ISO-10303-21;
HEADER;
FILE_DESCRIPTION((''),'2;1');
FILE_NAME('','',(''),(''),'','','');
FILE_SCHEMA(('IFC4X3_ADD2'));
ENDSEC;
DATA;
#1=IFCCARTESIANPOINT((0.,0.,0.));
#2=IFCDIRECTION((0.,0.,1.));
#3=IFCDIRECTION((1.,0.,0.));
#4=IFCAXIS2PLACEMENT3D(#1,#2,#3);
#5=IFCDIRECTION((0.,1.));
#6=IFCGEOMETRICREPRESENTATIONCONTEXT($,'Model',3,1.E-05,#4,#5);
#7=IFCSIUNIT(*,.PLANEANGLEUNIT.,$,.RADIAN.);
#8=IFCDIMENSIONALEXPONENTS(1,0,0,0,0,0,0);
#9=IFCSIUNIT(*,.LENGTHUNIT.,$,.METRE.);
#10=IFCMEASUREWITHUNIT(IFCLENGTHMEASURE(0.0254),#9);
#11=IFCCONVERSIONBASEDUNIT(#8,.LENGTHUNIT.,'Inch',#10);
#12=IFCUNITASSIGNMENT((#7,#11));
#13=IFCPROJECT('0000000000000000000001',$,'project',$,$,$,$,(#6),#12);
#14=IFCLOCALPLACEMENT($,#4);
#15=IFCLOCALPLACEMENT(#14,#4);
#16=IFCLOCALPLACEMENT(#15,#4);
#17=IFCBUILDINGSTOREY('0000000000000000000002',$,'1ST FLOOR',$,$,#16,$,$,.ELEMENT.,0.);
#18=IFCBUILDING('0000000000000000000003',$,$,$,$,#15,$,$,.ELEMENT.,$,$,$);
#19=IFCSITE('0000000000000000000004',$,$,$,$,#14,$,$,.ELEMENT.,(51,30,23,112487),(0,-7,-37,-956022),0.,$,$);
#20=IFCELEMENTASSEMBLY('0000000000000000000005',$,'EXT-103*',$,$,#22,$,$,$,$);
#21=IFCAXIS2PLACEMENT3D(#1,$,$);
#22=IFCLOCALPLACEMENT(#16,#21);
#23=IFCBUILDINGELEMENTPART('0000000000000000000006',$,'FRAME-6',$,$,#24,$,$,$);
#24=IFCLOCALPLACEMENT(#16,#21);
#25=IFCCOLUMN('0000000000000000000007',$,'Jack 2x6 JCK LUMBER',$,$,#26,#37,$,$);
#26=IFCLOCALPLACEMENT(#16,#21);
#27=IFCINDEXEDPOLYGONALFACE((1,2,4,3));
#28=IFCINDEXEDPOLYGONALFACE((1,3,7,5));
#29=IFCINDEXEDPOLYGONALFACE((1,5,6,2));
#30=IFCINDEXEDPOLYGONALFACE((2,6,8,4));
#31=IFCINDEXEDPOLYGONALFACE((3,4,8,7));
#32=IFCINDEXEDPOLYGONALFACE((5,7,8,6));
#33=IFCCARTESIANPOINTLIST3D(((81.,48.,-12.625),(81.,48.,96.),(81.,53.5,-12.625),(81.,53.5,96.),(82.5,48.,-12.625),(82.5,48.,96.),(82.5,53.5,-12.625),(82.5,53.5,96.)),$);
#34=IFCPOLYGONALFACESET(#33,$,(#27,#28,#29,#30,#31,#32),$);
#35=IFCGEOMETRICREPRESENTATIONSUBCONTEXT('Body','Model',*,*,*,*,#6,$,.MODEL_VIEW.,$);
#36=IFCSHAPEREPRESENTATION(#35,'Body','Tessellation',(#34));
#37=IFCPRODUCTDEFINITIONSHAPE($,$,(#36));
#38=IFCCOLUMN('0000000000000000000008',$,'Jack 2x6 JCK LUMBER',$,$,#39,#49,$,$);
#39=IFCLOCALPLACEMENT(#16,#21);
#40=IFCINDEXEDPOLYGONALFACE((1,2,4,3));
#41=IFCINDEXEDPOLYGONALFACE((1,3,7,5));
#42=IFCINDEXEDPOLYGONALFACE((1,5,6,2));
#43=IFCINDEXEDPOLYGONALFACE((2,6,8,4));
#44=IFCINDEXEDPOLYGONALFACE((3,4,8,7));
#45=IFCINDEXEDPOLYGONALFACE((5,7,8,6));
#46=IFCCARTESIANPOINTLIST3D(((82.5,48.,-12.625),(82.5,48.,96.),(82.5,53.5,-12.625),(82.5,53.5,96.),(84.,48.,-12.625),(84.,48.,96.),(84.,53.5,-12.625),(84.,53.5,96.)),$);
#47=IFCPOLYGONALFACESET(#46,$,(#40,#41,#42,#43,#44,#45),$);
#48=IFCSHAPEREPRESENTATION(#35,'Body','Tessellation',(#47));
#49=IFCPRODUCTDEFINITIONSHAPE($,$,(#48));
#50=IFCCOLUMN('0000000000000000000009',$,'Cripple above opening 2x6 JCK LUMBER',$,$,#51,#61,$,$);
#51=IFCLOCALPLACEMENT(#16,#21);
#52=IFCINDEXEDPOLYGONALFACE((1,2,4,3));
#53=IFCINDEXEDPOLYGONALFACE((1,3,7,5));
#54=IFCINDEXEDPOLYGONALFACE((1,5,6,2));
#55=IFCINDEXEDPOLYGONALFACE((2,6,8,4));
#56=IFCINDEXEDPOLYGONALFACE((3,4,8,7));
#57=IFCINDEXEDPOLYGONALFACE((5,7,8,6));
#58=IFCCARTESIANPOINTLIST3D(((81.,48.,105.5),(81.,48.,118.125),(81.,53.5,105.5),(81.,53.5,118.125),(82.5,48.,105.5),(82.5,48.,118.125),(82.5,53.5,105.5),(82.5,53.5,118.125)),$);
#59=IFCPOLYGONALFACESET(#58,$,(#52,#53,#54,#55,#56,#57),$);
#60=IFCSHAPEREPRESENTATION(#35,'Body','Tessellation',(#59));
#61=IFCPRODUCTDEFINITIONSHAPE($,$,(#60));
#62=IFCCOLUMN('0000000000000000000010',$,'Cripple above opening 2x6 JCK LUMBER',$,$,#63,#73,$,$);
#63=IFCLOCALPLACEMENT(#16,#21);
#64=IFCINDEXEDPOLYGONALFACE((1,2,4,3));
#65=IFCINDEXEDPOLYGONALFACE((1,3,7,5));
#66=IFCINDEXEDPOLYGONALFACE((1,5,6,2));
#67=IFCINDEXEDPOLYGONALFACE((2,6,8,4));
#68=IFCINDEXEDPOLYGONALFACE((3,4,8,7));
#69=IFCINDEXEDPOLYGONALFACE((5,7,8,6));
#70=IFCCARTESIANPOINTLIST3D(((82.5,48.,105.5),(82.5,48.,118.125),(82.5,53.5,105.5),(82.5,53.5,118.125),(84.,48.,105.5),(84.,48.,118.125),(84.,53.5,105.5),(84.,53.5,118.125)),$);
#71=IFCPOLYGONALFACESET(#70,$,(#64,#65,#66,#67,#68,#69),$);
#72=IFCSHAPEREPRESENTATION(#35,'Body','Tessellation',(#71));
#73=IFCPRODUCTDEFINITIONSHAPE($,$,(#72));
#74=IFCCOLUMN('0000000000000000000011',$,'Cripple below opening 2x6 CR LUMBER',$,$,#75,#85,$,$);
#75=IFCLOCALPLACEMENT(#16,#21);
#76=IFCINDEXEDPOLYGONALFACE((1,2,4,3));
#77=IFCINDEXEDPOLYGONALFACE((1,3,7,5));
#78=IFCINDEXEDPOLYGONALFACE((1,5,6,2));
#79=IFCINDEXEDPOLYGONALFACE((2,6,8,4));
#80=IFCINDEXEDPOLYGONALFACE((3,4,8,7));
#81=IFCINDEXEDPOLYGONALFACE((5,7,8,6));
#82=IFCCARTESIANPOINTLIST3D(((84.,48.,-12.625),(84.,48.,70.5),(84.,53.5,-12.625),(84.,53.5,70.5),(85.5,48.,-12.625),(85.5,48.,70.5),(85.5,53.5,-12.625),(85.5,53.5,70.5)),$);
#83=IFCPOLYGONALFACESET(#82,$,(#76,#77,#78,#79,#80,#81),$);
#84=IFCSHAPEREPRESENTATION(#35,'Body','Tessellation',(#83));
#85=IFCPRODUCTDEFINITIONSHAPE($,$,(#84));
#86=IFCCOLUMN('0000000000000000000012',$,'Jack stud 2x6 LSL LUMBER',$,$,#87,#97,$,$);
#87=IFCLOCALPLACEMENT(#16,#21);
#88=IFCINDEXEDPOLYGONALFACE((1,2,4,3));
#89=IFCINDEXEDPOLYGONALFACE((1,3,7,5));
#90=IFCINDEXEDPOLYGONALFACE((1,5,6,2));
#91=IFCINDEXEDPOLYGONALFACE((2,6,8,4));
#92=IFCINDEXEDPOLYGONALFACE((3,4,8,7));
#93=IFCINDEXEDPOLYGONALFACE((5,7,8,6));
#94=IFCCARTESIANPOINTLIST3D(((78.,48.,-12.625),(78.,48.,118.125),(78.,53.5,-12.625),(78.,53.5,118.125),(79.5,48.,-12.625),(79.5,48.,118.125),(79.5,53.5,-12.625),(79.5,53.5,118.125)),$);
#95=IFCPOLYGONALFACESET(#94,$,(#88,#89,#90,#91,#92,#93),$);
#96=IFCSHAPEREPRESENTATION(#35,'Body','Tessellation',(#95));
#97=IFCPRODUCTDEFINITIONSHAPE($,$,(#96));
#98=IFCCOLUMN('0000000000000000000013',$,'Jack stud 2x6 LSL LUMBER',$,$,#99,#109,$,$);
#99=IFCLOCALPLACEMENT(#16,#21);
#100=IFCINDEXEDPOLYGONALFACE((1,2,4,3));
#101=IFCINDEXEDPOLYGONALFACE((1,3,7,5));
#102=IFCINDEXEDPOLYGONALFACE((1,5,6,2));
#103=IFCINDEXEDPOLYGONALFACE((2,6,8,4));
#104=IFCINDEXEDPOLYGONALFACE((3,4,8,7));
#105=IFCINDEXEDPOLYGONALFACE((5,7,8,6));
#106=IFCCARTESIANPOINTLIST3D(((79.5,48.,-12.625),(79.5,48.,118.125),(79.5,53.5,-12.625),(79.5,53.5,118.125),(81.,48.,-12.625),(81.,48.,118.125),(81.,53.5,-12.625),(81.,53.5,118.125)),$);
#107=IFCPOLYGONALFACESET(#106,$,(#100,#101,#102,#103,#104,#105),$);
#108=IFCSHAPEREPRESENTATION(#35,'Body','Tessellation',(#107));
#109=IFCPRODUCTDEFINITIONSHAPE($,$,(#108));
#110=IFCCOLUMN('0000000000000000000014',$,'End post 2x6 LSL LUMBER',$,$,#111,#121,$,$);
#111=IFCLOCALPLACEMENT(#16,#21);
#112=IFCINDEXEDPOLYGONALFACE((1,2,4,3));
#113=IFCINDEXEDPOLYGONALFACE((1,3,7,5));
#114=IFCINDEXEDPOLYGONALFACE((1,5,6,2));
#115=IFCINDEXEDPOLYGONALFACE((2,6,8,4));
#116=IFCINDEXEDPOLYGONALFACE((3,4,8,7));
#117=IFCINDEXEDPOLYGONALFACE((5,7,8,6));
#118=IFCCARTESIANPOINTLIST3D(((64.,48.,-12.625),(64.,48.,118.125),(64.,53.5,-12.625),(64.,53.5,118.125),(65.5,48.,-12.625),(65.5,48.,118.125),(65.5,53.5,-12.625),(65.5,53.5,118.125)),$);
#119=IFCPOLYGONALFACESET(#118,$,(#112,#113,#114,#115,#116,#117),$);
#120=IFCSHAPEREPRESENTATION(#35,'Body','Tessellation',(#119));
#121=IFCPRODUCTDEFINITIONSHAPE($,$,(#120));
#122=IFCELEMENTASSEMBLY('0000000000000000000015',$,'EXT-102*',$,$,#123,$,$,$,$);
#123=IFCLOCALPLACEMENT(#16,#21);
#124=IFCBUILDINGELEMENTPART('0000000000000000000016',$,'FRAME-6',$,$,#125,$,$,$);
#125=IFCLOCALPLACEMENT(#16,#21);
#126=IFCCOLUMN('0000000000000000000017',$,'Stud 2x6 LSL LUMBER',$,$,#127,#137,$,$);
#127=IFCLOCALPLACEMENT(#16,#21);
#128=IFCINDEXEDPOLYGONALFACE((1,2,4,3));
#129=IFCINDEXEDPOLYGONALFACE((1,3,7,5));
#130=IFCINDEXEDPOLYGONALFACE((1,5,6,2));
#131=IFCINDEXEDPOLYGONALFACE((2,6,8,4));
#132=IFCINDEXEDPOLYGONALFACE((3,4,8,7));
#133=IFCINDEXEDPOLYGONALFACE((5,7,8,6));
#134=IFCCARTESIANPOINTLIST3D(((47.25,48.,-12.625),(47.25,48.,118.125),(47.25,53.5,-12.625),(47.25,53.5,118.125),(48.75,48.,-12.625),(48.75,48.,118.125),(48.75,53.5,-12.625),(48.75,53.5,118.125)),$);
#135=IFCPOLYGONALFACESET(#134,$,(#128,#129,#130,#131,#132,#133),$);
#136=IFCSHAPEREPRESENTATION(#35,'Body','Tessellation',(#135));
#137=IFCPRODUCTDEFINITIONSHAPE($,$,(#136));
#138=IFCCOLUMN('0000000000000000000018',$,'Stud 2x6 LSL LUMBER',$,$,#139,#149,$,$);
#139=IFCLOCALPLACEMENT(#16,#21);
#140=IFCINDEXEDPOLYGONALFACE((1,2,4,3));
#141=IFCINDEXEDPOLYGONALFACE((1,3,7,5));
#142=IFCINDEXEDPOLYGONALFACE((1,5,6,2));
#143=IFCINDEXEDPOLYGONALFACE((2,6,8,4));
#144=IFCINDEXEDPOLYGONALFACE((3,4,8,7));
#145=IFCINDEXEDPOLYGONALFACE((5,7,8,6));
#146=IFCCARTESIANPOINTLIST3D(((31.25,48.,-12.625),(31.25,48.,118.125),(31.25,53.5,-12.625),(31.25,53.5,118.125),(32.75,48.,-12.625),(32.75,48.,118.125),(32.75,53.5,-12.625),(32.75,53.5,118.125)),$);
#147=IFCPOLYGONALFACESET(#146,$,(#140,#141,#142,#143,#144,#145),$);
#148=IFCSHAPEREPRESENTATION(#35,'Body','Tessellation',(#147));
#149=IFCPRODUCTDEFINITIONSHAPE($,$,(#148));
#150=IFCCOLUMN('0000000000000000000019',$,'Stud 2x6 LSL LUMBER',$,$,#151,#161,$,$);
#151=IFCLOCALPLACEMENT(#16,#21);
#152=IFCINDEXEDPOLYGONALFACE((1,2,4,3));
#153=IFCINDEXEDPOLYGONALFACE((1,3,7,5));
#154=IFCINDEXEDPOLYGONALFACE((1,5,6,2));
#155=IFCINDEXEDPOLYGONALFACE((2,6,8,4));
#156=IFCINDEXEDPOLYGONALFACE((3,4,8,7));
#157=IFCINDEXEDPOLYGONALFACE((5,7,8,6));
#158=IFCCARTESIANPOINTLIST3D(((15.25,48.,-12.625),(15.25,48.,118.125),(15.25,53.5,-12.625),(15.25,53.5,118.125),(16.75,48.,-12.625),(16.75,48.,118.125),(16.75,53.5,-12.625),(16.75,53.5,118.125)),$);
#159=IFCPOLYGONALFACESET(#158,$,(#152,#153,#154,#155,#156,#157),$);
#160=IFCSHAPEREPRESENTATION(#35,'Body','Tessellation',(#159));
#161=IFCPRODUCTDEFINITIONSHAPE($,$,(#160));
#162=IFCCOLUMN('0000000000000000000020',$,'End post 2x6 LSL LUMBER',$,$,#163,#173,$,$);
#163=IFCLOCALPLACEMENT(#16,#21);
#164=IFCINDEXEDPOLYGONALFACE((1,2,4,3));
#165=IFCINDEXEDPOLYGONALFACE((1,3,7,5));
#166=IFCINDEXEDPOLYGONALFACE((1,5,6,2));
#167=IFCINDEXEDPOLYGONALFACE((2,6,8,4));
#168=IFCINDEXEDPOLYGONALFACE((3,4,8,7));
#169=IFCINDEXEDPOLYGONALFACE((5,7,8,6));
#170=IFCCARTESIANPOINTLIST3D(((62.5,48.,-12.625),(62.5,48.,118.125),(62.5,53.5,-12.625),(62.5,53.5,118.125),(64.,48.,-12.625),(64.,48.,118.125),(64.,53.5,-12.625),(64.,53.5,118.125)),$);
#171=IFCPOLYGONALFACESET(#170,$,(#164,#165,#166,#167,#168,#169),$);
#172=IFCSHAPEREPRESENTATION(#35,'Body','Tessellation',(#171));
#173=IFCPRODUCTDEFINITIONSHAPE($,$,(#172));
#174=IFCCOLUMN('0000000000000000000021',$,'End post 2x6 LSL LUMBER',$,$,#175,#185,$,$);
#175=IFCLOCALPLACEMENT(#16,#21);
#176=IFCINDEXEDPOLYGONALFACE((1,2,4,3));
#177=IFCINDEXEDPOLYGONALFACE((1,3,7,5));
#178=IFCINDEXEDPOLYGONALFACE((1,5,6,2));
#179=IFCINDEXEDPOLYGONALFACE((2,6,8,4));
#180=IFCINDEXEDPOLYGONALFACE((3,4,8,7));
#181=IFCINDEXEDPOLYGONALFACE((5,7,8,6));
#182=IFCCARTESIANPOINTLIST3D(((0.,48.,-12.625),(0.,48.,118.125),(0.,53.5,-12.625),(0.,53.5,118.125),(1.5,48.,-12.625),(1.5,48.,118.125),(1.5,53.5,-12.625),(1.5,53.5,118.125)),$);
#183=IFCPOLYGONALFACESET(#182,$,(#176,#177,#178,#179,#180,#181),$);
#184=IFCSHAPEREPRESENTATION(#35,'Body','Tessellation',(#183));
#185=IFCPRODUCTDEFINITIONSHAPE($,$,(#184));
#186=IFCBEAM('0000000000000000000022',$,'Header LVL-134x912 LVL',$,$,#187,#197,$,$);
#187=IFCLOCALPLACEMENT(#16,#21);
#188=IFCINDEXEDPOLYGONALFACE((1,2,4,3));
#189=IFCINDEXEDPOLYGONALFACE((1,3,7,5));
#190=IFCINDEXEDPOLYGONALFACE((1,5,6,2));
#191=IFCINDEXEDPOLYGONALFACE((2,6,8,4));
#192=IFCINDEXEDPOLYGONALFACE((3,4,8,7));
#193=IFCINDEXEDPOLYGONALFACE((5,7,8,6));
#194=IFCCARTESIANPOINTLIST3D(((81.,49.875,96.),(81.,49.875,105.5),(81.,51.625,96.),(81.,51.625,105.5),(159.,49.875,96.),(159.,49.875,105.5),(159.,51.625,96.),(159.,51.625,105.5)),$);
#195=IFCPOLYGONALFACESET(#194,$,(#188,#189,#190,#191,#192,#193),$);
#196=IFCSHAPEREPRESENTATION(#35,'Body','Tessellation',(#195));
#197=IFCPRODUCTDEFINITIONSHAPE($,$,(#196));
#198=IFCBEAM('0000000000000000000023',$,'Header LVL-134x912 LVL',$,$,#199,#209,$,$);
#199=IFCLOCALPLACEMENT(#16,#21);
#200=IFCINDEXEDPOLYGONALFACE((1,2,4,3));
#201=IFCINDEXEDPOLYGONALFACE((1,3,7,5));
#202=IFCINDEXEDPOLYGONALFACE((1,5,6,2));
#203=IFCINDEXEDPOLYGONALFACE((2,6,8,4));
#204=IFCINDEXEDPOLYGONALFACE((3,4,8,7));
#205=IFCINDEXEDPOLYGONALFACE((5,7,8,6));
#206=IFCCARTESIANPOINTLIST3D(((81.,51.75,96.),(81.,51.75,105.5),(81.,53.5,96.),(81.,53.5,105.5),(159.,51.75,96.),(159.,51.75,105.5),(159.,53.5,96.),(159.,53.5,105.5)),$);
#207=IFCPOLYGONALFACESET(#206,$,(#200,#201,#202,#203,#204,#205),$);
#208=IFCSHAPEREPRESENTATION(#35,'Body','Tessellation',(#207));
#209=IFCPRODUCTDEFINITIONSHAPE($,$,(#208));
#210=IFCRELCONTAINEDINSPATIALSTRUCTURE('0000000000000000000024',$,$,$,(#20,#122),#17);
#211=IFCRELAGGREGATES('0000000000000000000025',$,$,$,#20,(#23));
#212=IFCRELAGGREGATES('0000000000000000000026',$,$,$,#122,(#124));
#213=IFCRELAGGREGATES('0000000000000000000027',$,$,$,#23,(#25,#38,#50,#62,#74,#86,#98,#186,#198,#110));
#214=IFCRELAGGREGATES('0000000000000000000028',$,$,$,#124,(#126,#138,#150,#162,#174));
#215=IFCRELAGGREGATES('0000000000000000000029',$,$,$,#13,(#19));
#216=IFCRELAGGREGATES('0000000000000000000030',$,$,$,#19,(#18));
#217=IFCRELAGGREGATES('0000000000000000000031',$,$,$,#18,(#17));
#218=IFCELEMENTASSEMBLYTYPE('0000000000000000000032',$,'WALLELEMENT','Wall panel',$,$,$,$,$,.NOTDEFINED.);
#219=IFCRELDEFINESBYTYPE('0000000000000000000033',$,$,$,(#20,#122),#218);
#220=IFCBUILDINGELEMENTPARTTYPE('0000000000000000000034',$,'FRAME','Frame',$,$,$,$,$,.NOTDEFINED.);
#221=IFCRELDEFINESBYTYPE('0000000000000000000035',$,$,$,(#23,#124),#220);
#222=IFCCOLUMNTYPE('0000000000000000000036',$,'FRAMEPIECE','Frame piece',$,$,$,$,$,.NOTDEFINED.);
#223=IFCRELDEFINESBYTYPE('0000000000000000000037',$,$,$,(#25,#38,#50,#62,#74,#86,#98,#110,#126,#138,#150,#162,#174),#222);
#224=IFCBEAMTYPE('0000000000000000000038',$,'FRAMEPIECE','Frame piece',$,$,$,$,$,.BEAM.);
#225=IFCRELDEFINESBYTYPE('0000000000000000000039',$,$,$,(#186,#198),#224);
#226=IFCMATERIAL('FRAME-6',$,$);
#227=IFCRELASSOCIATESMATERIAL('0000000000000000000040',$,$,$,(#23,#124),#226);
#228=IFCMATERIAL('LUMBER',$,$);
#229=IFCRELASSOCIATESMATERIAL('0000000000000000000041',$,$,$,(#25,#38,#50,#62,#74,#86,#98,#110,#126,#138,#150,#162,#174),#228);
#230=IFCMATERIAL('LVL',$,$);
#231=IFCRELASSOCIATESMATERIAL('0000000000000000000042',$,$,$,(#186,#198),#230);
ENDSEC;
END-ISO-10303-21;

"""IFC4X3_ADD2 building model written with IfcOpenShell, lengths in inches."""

from ifc_helpers import new_model, entity, si_unit, converted_unit, direction, frame, origin_with_axes, origin_2d_with_axis, place, context, subcontext, project, spatial, rectangle, extrude, material, type_object, element, aggregate, save


model = new_model("IFC4X3_ADD2")

# Units and contexts
model_context = context("Model", 3, precision=1e-05, world=origin_with_axes(), true_north=direction((0.0, 1.0)))
body_context = subcontext(model_context, "Body", "Model", "MODEL_VIEW")
ifc_project = project(units=[si_unit("PLANEANGLEUNIT", "RADIAN"), converted_unit("LENGTHUNIT", "Inch", entity("IfcLengthMeasure", 0.0254), si_unit("LENGTHUNIT", "METRE"), dimensions=[1, 0, 0, 0, 0, 0, 0])], contexts=[model_context])

# Site, building, storey
site_placement = place(None, origin_with_axes())
site = spatial("IfcSite", under=ifc_project, at=site_placement, CompositionType="ELEMENT", RefLatitude=(51, 30, 23, 112487), RefLongitude=(0, -7, -37, -956022), RefElevation=0.0)
building_placement = place(site_placement, origin_with_axes())
building = spatial("IfcBuilding", under=site, at=building_placement, CompositionType="ELEMENT")
storey_placement = place(building_placement, origin_with_axes())
storey = spatial("IfcBuildingStorey", under=building, at=storey_placement, Name="1ST FLOOR", CompositionType="ELEMENT", Elevation=0.0)

# Element assemblies, building element parts, columns
element_assembly_type = type_object("IfcElementAssemblyType", Name="WALLELEMENT", Description="Wall panel", PredefinedType="NOTDEFINED")
assembly_1_placement = place(storey_placement, origin_with_axes())
assembly_1 = element("IfcElementAssembly", 1, at=assembly_1_placement, inside=storey, type_object=element_assembly_type, Name="EXT-103*")
ifc_material_1 = material(Name="FRAME-6")
building_element_part_type = type_object("IfcBuildingElementPartType", Name="FRAME", Description="Frame", PredefinedType="NOTDEFINED")
building_element_part_1_placement = place(storey_placement, origin_with_axes())
building_element_part_1 = element("IfcBuildingElementPart", 2, at=building_element_part_1_placement, type_object=building_element_part_type, material=ifc_material_1, Name="FRAME-6")
aggregate(assembly_1, [building_element_part_1])
ifc_material_2 = material(Name="LUMBER")
column_type = type_object("IfcColumnType", Name="FRAMEPIECE", Description="Frame piece", PredefinedType="NOTDEFINED")
column_1_placement = place(storey_placement, frame((81.75, 50.75, 96.0), z_axis=(0.0, 0.0, -1.0), x_axis=(1.0, 0.0, 0.0)))
column_1 = element("IfcColumn", 3, at=column_1_placement, type_object=column_type, material=ifc_material_2, Name="Jack 2x6 JCK LUMBER", context=body_context, shape_type="SweptSolid", body=[
    extrude(rectangle(XDim=1.5, YDim=5.5, at=origin_2d_with_axis()), origin_with_axes(), (0.0, 0.0, 1.0), 108.625),
])
column_2_placement = place(storey_placement, frame((83.25, 50.75, 96.0), z_axis=(0.0, 0.0, -1.0), x_axis=(1.0, 0.0, 0.0)))
column_2 = element("IfcColumn", 4, at=column_2_placement, type_object=column_type, material=ifc_material_2, Name="Jack 2x6 JCK LUMBER", context=body_context, shape_type="SweptSolid", body=[
    extrude(rectangle(XDim=1.5, YDim=5.5, at=origin_2d_with_axis()), origin_with_axes(), (0.0, 0.0, 1.0), 108.625),
])
column_3_placement = place(storey_placement, frame((81.75, 50.75, 118.125), z_axis=(0.0, 0.0, -1.0), x_axis=(1.0, 0.0, 0.0)))
column_3 = element("IfcColumn", 5, at=column_3_placement, type_object=column_type, material=ifc_material_2, Name="Cripple above opening 2x6 JCK LUMBER", context=body_context, shape_type="SweptSolid", body=[
    extrude(rectangle(XDim=1.5, YDim=5.5, at=origin_2d_with_axis()), origin_with_axes(), (0.0, 0.0, 1.0), 12.625),
])
column_4_placement = place(storey_placement, frame((83.25, 50.75, 118.125), z_axis=(0.0, 0.0, -1.0), x_axis=(1.0, 0.0, 0.0)))
column_4 = element("IfcColumn", 6, at=column_4_placement, type_object=column_type, material=ifc_material_2, Name="Cripple above opening 2x6 JCK LUMBER", context=body_context, shape_type="SweptSolid", body=[
    extrude(rectangle(XDim=1.5, YDim=5.5, at=origin_2d_with_axis()), origin_with_axes(), (0.0, 0.0, 1.0), 12.625),
])
column_5_placement = place(storey_placement, frame((84.75, 50.75, 70.5), z_axis=(0.0, 0.0, -1.0), x_axis=(1.0, 0.0, 0.0)))
column_5 = element("IfcColumn", 7, at=column_5_placement, type_object=column_type, material=ifc_material_2, Name="Cripple below opening 2x6 CR LUMBER", context=body_context, shape_type="SweptSolid", body=[
    extrude(rectangle(XDim=1.5, YDim=5.5, at=origin_2d_with_axis()), origin_with_axes(), (0.0, 0.0, 1.0), 83.125),
])
column_6_placement = place(storey_placement, frame((78.75, 50.75, 118.125), z_axis=(0.0, 0.0, -1.0), x_axis=(1.0, 0.0, 0.0)))
column_6 = element("IfcColumn", 8, at=column_6_placement, type_object=column_type, material=ifc_material_2, Name="Jack stud 2x6 LSL LUMBER", context=body_context, shape_type="SweptSolid", body=[
    extrude(rectangle(XDim=1.5, YDim=5.5, at=origin_2d_with_axis()), origin_with_axes(), (0.0, 0.0, 1.0), 130.75),
])
column_7_placement = place(storey_placement, frame((80.25, 50.75, 118.125), z_axis=(0.0, 0.0, -1.0), x_axis=(1.0, 0.0, 0.0)))
column_7 = element("IfcColumn", 9, at=column_7_placement, type_object=column_type, material=ifc_material_2, Name="Jack stud 2x6 LSL LUMBER", context=body_context, shape_type="SweptSolid", body=[
    extrude(rectangle(XDim=1.5, YDim=5.5, at=origin_2d_with_axis()), origin_with_axes(), (0.0, 0.0, 1.0), 130.75),
])
column_8_placement = place(storey_placement, frame((64.75, 50.75, 118.125), z_axis=(0.0, 0.0, -1.0), x_axis=(1.0, 0.0, 0.0)))
column_8 = element("IfcColumn", 10, at=column_8_placement, type_object=column_type, material=ifc_material_2, Name="End post 2x6 LSL LUMBER", context=body_context, shape_type="SweptSolid", body=[
    extrude(rectangle(XDim=1.5, YDim=5.5, at=origin_2d_with_axis()), origin_with_axes(), (0.0, 0.0, 1.0), 130.75),
])
assembly_2_placement = place(storey_placement, origin_with_axes())
assembly_2 = element("IfcElementAssembly", 11, at=assembly_2_placement, inside=storey, type_object=element_assembly_type, Name="EXT-102*")
building_element_part_2_placement = place(storey_placement, origin_with_axes())
building_element_part_2 = element("IfcBuildingElementPart", 12, at=building_element_part_2_placement, type_object=building_element_part_type, material=ifc_material_1, Name="FRAME-6")
aggregate(assembly_2, [building_element_part_2])
column_9_placement = place(storey_placement, frame((48.0, 50.75, 118.125), z_axis=(0.0, 0.0, -1.0), x_axis=(1.0, 0.0, 0.0)))
column_9 = element("IfcColumn", 13, at=column_9_placement, type_object=column_type, material=ifc_material_2, Name="Stud 2x6 LSL LUMBER", context=body_context, shape_type="SweptSolid", body=[
    extrude(rectangle(XDim=1.5, YDim=5.5, at=origin_2d_with_axis()), origin_with_axes(), (0.0, 0.0, 1.0), 130.75),
])
column_10_placement = place(storey_placement, frame((32.0, 50.75, 118.125), z_axis=(0.0, 0.0, -1.0), x_axis=(1.0, 0.0, 0.0)))
column_10 = element("IfcColumn", 14, at=column_10_placement, type_object=column_type, material=ifc_material_2, Name="Stud 2x6 LSL LUMBER", context=body_context, shape_type="SweptSolid", body=[
    extrude(rectangle(XDim=1.5, YDim=5.5, at=origin_2d_with_axis()), origin_with_axes(), (0.0, 0.0, 1.0), 130.75),
])
column_11_placement = place(storey_placement, frame((16.0, 50.75, 118.125), z_axis=(0.0, 0.0, -1.0), x_axis=(1.0, 0.0, 0.0)))
column_11 = element("IfcColumn", 15, at=column_11_placement, type_object=column_type, material=ifc_material_2, Name="Stud 2x6 LSL LUMBER", context=body_context, shape_type="SweptSolid", body=[
    extrude(rectangle(XDim=1.5, YDim=5.5, at=origin_2d_with_axis()), origin_with_axes(), (0.0, 0.0, 1.0), 130.75),
])
column_12_placement = place(storey_placement, frame((63.25, 50.75, -12.625), z_axis=(0.0, 0.0, 1.0), x_axis=(-1.0, 0.0, 0.0)))
column_12 = element("IfcColumn", 16, at=column_12_placement, type_object=column_type, material=ifc_material_2, Name="End post 2x6 LSL LUMBER", context=body_context, shape_type="SweptSolid", body=[
    extrude(rectangle(XDim=1.5, YDim=5.5, at=origin_2d_with_axis()), origin_with_axes(), (0.0, 0.0, 1.0), 130.75),
])
column_13_placement = place(storey_placement, frame((0.75, 50.75, 118.125), z_axis=(0.0, 0.0, -1.0), x_axis=(1.0, 0.0, 0.0)))
column_13 = element("IfcColumn", 17, at=column_13_placement, type_object=column_type, material=ifc_material_2, Name="End post 2x6 LSL LUMBER", context=body_context, shape_type="SweptSolid", body=[
    extrude(rectangle(XDim=1.5, YDim=5.5, at=origin_2d_with_axis()), origin_with_axes(), (0.0, 0.0, 1.0), 130.75),
])

# Beams
ifc_material_3 = material(Name="LVL")
beam_type = type_object("IfcBeamType", Name="FRAMEPIECE", Description="Frame piece", PredefinedType="BEAM")
beam_1_placement = place(storey_placement, frame((81.0, 50.75, 100.75), z_axis=(1.0, 0.0, 0.0), x_axis=(0.0, 1.0, 0.0)))
beam_1 = element("IfcBeam", 18, at=beam_1_placement, type_object=beam_type, material=ifc_material_3, Name="Header LVL-134x912 LVL", context=body_context, shape_type="SweptSolid", body=[
    extrude(rectangle(XDim=1.75, YDim=9.5, at=origin_2d_with_axis()), origin_with_axes(), (0.0, 0.0, 1.0), 78.0),
])
beam_2_placement = place(storey_placement, frame((81.0, 52.625, 100.75), z_axis=(1.0, 0.0, 0.0), x_axis=(0.0, 1.0, 0.0)))
beam_2 = element("IfcBeam", 19, at=beam_2_placement, type_object=beam_type, material=ifc_material_3, Name="Header LVL-134x912 LVL", context=body_context, shape_type="SweptSolid", body=[
    extrude(rectangle(XDim=1.75, YDim=9.5, at=origin_2d_with_axis()), origin_with_axes(), (0.0, 0.0, 1.0), 78.0),
])
aggregate(building_element_part_1, [column_1, column_2, column_3, column_4, column_5, column_6, column_7, beam_1, beam_2, column_8])
aggregate(building_element_part_2, [column_9, column_10, column_11, column_12, column_13])

save(model, "model.ifc")
